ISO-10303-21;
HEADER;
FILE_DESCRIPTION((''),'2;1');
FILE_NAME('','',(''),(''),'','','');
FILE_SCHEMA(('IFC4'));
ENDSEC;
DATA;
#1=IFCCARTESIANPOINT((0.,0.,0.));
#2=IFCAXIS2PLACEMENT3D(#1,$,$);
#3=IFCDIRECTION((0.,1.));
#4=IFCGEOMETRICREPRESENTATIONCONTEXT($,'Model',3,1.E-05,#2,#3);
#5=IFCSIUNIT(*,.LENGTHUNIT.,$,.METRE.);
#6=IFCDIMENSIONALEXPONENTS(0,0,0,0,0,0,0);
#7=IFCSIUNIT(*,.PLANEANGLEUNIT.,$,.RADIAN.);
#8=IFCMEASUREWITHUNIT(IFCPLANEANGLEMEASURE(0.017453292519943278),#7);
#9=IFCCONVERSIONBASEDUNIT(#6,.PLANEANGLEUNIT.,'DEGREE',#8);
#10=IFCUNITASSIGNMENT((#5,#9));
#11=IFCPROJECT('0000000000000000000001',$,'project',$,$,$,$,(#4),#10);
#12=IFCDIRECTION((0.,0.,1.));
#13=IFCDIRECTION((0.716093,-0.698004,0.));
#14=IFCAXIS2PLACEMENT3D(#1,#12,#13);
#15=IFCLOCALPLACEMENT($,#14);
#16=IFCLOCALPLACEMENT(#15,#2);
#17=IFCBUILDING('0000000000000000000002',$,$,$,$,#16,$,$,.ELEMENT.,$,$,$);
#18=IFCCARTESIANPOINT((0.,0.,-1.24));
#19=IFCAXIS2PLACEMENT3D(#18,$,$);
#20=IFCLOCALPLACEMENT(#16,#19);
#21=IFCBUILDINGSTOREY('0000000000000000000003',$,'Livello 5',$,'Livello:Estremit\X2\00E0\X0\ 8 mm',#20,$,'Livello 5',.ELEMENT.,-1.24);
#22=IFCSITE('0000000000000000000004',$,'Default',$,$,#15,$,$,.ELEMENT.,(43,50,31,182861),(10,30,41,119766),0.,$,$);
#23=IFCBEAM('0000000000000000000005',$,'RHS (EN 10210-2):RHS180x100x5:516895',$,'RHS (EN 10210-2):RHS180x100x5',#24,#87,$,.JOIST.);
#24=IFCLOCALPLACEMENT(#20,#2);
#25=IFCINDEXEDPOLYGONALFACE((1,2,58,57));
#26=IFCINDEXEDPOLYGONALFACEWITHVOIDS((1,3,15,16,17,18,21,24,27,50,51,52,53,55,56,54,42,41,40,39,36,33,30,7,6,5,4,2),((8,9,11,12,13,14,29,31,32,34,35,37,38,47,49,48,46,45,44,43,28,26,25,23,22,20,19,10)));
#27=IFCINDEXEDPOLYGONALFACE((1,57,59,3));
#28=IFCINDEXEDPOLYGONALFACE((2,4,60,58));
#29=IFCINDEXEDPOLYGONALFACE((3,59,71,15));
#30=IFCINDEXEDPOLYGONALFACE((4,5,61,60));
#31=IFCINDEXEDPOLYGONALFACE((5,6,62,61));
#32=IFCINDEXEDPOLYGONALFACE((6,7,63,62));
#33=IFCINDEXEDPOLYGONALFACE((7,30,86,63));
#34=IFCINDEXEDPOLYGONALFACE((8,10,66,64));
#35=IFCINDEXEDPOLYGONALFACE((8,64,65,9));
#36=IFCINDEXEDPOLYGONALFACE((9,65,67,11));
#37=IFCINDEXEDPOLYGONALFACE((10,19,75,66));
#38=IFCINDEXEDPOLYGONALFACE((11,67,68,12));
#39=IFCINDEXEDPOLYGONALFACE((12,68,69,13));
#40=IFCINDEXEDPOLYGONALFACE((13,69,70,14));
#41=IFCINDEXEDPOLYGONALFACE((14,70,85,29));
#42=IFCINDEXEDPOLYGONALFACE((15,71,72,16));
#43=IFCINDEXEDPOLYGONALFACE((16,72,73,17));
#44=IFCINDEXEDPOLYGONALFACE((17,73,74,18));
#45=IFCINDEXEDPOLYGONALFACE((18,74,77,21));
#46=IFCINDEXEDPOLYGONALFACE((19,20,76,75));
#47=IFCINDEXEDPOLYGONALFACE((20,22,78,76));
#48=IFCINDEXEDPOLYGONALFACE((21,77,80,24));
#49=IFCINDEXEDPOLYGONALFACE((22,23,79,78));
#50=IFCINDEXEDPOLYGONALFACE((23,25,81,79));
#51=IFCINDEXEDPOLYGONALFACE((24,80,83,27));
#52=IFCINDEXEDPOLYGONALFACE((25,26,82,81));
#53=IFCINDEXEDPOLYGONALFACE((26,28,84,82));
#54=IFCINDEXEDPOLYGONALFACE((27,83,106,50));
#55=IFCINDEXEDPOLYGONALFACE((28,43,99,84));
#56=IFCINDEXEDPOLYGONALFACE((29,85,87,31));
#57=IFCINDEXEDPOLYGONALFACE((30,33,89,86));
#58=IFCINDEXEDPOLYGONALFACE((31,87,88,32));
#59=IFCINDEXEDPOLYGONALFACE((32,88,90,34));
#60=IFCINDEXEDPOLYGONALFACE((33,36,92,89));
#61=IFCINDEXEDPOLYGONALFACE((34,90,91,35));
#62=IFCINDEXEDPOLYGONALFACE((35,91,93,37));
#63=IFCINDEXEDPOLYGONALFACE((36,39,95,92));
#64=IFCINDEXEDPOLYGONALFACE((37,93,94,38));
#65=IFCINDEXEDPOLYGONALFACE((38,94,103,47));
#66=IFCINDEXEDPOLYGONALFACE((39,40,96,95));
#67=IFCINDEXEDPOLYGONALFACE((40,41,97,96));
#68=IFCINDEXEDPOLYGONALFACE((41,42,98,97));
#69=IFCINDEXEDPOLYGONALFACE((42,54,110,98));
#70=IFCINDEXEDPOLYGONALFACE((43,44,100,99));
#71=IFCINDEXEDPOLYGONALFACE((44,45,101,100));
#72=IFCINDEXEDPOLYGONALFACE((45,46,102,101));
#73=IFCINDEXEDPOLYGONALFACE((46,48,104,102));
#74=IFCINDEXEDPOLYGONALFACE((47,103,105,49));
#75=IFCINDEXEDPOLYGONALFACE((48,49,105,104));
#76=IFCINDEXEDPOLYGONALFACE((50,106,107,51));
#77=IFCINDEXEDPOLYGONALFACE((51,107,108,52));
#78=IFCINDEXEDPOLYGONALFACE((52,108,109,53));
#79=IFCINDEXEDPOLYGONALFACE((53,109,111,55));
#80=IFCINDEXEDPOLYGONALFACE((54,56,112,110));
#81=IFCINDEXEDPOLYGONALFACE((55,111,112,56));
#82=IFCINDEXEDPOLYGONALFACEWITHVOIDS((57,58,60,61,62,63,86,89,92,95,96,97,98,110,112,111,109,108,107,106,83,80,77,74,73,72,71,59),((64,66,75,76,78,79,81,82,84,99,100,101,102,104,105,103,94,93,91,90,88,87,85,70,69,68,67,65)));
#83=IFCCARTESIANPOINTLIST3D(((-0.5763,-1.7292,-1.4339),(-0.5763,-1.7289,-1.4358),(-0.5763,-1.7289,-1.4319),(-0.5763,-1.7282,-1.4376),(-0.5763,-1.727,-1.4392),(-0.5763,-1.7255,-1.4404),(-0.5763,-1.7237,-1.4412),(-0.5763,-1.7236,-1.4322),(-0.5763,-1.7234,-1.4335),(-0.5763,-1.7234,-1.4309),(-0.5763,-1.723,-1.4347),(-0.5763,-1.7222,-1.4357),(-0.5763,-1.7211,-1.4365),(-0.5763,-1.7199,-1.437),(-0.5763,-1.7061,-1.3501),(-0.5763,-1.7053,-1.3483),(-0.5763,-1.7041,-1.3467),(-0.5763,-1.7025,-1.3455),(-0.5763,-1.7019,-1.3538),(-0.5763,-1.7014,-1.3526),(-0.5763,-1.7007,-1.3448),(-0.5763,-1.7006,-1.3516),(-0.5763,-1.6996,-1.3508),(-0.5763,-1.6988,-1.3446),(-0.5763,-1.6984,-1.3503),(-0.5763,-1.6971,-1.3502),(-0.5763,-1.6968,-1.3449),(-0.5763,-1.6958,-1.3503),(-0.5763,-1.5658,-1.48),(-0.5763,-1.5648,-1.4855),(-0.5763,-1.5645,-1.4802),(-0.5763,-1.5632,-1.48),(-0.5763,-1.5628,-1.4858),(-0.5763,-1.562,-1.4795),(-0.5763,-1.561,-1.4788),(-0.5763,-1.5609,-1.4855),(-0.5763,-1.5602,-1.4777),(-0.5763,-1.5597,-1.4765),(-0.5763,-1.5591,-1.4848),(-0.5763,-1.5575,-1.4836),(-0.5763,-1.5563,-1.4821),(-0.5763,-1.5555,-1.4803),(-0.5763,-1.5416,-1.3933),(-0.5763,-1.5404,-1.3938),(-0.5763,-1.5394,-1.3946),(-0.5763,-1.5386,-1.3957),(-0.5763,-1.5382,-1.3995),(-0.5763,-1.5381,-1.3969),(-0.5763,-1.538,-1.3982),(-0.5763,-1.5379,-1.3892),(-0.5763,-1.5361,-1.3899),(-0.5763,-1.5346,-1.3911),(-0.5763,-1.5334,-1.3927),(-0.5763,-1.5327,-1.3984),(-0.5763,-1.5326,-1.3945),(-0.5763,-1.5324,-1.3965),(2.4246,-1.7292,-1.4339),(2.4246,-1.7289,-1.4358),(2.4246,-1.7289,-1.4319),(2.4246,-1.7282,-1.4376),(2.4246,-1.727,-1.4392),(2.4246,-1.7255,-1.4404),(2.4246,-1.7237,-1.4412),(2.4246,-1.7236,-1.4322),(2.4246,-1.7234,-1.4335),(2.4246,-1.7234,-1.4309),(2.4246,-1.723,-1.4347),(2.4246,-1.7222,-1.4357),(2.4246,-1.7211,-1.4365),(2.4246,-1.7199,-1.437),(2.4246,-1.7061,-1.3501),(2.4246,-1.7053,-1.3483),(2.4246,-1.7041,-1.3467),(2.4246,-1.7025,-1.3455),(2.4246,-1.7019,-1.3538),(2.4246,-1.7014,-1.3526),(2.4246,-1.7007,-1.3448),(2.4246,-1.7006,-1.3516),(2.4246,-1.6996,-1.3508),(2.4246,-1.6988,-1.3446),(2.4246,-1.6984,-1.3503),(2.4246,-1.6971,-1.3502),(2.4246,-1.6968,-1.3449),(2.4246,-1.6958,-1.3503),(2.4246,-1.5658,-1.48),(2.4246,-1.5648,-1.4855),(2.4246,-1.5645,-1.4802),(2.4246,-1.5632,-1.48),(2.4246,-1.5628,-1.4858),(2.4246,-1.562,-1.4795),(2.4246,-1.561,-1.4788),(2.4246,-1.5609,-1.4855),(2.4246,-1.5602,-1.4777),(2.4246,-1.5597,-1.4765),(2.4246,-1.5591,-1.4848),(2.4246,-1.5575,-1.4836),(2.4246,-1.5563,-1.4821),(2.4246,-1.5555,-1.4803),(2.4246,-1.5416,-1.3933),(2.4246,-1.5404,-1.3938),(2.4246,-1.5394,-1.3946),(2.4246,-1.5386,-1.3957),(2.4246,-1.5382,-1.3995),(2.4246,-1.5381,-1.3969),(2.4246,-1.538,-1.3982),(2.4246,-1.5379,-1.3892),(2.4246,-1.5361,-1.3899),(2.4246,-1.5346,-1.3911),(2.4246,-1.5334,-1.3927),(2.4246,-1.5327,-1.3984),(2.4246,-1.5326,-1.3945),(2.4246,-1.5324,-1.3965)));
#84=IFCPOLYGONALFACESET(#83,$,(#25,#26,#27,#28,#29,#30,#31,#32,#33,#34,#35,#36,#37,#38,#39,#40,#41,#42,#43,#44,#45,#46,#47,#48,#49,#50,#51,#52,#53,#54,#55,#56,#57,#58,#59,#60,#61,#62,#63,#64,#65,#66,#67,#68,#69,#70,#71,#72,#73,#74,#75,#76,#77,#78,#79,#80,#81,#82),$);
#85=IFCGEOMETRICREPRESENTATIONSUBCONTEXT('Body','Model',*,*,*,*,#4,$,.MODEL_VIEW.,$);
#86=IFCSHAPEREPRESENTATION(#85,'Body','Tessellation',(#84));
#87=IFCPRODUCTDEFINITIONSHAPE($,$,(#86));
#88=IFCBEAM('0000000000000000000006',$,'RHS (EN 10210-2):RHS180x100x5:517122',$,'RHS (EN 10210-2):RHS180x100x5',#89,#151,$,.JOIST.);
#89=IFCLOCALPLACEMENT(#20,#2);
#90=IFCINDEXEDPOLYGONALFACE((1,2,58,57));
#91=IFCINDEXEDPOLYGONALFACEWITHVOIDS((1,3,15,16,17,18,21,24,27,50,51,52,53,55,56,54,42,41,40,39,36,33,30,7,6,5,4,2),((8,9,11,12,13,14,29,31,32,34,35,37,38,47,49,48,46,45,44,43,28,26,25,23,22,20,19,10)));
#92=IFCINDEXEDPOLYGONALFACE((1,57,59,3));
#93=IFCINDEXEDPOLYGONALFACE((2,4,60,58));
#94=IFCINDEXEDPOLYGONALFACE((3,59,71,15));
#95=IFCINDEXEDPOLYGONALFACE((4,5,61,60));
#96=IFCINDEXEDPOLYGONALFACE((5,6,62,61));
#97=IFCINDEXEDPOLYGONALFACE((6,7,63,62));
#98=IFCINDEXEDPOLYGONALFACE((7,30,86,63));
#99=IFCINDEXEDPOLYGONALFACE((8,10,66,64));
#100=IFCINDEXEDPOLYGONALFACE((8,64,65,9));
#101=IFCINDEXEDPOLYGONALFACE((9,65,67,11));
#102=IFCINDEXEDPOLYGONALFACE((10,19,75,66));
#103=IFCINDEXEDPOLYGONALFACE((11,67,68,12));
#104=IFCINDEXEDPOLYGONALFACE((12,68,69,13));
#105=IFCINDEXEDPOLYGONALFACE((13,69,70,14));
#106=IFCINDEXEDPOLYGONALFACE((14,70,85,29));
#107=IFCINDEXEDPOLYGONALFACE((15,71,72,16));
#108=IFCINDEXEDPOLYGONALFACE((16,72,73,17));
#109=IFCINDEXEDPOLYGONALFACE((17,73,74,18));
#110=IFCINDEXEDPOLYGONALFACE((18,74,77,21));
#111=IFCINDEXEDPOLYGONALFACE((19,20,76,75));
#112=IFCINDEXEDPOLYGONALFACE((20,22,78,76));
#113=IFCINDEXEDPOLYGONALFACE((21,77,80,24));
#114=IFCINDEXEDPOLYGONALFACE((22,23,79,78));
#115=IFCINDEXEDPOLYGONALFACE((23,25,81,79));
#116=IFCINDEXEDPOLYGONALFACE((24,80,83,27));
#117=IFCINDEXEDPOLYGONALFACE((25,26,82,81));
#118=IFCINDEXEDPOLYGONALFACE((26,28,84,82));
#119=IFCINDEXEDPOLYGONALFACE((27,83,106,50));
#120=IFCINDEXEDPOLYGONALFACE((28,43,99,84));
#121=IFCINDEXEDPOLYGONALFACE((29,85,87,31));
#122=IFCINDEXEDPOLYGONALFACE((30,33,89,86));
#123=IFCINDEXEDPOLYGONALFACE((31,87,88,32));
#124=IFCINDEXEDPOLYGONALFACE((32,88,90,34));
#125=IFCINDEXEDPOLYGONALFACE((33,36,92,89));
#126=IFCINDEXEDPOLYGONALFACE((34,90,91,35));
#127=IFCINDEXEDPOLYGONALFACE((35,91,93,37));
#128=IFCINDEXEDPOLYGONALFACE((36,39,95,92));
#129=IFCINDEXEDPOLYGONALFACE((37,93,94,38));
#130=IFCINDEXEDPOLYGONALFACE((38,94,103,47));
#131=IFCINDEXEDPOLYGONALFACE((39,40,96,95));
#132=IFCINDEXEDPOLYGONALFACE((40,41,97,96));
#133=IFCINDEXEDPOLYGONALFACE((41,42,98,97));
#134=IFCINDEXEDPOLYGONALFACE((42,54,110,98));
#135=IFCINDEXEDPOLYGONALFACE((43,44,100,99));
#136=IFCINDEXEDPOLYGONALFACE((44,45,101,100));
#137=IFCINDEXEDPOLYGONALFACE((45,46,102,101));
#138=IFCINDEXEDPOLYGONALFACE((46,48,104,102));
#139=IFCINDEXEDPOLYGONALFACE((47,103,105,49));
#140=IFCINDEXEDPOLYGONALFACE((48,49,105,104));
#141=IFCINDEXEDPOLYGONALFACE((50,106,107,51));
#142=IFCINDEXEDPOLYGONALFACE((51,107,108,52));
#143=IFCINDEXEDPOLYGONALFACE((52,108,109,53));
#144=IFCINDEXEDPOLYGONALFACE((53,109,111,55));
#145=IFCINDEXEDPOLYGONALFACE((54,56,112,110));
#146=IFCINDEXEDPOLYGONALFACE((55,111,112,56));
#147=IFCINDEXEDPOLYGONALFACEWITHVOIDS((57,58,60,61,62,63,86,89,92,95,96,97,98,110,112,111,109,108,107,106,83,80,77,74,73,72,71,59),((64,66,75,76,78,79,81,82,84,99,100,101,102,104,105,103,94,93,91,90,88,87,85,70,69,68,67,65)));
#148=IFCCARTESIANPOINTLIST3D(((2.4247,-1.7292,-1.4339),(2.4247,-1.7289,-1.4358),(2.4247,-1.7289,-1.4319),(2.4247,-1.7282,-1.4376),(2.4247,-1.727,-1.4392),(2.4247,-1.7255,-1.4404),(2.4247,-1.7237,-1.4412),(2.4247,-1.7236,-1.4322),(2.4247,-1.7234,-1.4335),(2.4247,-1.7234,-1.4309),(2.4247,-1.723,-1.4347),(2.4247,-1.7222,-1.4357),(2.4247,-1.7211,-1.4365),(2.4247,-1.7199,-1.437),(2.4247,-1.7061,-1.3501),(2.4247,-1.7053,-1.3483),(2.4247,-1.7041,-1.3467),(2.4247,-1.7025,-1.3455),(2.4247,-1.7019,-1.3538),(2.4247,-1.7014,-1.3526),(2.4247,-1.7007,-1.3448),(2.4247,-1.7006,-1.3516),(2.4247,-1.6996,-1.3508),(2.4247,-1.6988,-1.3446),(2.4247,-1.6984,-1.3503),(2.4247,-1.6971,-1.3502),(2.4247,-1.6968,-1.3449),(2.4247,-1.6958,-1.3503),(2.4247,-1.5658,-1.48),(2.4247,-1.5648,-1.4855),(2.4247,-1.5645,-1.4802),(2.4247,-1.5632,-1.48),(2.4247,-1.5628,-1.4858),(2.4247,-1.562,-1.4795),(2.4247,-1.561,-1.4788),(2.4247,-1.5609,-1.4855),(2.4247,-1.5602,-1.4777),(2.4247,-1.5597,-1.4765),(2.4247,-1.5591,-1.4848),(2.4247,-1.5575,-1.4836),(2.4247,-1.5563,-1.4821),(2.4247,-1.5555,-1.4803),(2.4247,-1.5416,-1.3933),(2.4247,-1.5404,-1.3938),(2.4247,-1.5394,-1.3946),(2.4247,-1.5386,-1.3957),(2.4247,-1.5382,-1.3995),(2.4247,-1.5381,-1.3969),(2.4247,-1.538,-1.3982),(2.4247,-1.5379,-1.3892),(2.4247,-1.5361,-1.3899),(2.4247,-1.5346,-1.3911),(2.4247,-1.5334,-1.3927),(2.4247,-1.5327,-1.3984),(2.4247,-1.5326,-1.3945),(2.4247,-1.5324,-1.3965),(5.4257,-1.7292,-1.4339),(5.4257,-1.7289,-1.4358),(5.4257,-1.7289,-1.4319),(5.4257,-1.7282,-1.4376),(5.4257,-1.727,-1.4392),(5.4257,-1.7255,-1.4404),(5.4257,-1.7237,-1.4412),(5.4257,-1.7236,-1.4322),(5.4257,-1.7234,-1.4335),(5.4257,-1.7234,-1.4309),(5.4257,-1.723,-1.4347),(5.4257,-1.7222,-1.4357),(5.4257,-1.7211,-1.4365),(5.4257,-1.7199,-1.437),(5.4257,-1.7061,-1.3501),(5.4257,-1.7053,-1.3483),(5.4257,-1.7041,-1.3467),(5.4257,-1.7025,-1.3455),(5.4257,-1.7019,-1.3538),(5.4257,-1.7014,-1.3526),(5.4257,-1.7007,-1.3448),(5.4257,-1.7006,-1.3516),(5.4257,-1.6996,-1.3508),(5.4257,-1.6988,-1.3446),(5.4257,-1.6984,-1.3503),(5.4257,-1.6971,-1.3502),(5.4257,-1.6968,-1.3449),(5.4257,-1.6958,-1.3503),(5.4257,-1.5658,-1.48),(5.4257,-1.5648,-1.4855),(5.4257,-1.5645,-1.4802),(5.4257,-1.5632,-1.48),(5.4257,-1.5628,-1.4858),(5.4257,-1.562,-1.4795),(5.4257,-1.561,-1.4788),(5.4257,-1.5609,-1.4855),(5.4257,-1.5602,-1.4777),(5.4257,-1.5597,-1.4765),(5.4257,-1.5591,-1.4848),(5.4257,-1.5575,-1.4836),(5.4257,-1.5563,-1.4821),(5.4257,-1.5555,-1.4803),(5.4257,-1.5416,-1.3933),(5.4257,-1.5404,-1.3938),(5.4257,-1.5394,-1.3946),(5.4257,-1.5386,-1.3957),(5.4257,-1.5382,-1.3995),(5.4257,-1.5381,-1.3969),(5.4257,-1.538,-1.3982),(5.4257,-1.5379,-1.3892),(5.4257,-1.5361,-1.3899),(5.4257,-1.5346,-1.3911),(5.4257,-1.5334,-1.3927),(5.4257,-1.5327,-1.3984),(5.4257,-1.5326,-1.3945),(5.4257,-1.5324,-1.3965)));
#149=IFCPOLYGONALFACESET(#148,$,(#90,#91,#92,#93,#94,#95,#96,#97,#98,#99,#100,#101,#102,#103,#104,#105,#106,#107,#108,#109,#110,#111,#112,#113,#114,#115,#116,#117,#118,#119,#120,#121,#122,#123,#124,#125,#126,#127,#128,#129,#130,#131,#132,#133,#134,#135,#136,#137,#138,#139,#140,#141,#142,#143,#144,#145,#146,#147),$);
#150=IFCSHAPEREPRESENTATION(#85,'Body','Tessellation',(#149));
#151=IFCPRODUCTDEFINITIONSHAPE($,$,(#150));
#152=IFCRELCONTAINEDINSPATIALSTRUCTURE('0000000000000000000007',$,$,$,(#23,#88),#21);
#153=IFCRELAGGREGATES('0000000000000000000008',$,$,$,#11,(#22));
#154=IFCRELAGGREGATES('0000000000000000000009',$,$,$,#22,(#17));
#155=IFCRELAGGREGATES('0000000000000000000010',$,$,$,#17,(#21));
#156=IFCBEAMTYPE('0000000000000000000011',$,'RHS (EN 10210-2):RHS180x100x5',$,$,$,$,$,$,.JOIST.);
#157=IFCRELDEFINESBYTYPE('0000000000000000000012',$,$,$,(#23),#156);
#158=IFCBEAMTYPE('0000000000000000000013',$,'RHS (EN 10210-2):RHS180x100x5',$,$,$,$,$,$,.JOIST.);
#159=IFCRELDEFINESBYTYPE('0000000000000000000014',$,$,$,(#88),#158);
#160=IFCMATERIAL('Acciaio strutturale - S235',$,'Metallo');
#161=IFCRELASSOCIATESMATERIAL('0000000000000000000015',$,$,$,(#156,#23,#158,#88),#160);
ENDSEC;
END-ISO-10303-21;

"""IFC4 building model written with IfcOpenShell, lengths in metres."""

from ifc_helpers import new_model, entity, si_unit, converted_unit, direction, frame, origin, place, context, subcontext, project, spatial, line, arc, indexed_curve, outline, extrude, source, transform, mapped, material, type_object, type_shapes, element, save


model = new_model("IFC4")

# Units and contexts
model_context = context("Model", 3, precision=1e-05, world=origin(), true_north=direction((0.0, 1.0)))
body_context = subcontext(model_context, "Body", "Model", "MODEL_VIEW")
ifc_project = project(units=[si_unit("LENGTHUNIT", "METRE"), converted_unit("PLANEANGLEUNIT", "DEGREE", entity("IfcPlaneAngleMeasure", 0.017453292519943278), si_unit("PLANEANGLEUNIT", "RADIAN"), dimensions=[0, 0, 0, 0, 0, 0, 0])], contexts=[model_context])

# Site, building, storey
site_placement = place(None, frame((0.0, 0.0, 0.0), z_axis=(0.0, 0.0, 1.0), x_axis=(0.716093, -0.698004, 0.0)))
site = spatial("IfcSite", under=ifc_project, at=site_placement, Name="Default", CompositionType="ELEMENT", RefLatitude=(43, 50, 31, 182861), RefLongitude=(10, 30, 41, 119766), RefElevation=0.0)
building_placement = place(site_placement, origin())
building = spatial("IfcBuilding", under=site, at=building_placement, CompositionType="ELEMENT")
storey_placement = place(building_placement, frame((0.0, 0.0, -1.24)))
storey = spatial("IfcBuildingStorey", under=building, at=storey_placement, Name="Livello 5", ObjectType="Livello:Estremità 8 mm", LongName="Livello 5", CompositionType="ELEMENT", Elevation=-1.24)

# Beams
ifc_material_1 = material(Name="Acciaio strutturale - S235", Category="Metallo")
beam_type_1 = type_object("IfcBeamType", Name="RHS (EN 10210-2):RHS180x100x5", PredefinedType="JOIST", material=ifc_material_1)
shared_shape_1 = source(origin(), body_context, "Body", "SweptSolid", [
    extrude(outline(indexed_curve([(-0.05, -0.0825), (-0.0478, -0.0878), (-0.0425, -0.09), (0.0425, -0.09), (0.0478, -0.0878), (0.05, -0.0825), (0.05, 0.0825), (0.0478, 0.0878), (0.0425, 0.09), (-0.0425, 0.09), (-0.0478, 0.0878), (-0.05, 0.0825)], segments=[arc(1, 2, 3), line(3, 4), arc(4, 5, 6), line(6, 7), arc(7, 8, 9), line(9, 10), arc(10, 11, 12), line(12, 1)], self_intersect=False), holes=[indexed_curve([(0.04, -0.085), (-0.04, -0.085), (-0.0435, -0.0835), (-0.045, -0.08), (-0.045, 0.08), (-0.0435, 0.0835), (-0.04, 0.085), (0.04, 0.085), (0.0435, 0.0835), (0.045, 0.08), (0.045, -0.08), (0.0435, -0.0835)], segments=[line(1, 2), arc(2, 3, 4), line(4, 5), arc(5, 6, 7), line(7, 8), arc(8, 9, 10), line(10, 11), arc(11, 12, 1)], self_intersect=False)]), frame((-1.5005, 0.0, 0.0), z_axis=(1.0, 0.0, 0.0), x_axis=(0.0, -1.0, 0.0)), (0.0, 0.0, 1.0), 3.0009),
])
type_shapes(beam_type_1, [shared_shape_1])
beam_1_placement = place(storey_placement, frame((0.9241, -1.6308, -1.4152), z_axis=(0.0, 0.963256, -0.268584), x_axis=(-1.0, 0.0, 0.0)))
element("IfcBeam", 1, at=beam_1_placement, inside=storey, type_object=beam_type_1, material=ifc_material_1, Name="RHS (EN 10210-2):RHS180x100x5:516895", ObjectType="RHS (EN 10210-2):RHS180x100x5", PredefinedType="JOIST", context=body_context, shape_type="MappedRepresentation", body=[
    mapped(shared_shape_1, transform((0.0, 0.0, 0.0), scale=1.0)),
])
beam_type_2 = type_object("IfcBeamType", Name="RHS (EN 10210-2):RHS180x100x5", PredefinedType="JOIST", material=ifc_material_1)
shared_shape_2 = source(origin(), body_context, "Body", "SweptSolid", [
    extrude(outline(indexed_curve([(-0.05, -0.0825), (-0.0478, -0.0878), (-0.0425, -0.09), (0.0425, -0.09), (0.0478, -0.0878), (0.05, -0.0825), (0.05, 0.0825), (0.0478, 0.0878), (0.0425, 0.09), (-0.0425, 0.09), (-0.0478, 0.0878), (-0.05, 0.0825)], segments=[arc(1, 2, 3), line(3, 4), arc(4, 5, 6), line(6, 7), arc(7, 8, 9), line(9, 10), arc(10, 11, 12), line(12, 1)], self_intersect=False), holes=[indexed_curve([(0.04, -0.085), (-0.04, -0.085), (-0.0435, -0.0835), (-0.045, -0.08), (-0.045, 0.08), (-0.0435, 0.0835), (-0.04, 0.085), (0.04, 0.085), (0.0435, 0.0835), (0.045, 0.08), (0.045, -0.08), (0.0435, -0.0835)], segments=[line(1, 2), arc(2, 3, 4), line(4, 5), arc(5, 6, 7), line(7, 8), arc(8, 9, 10), line(10, 11), arc(11, 12, 1)], self_intersect=False)]), frame((-1.5006, 0.0, 0.0), z_axis=(1.0, 0.0, 0.0), x_axis=(0.0, -1.0, 0.0)), (0.0, 0.0, 1.0), 3.001),
])
type_shapes(beam_type_2, [shared_shape_2])
beam_2_placement = place(storey_placement, frame((3.9251, -1.6308, -1.4152), z_axis=(0.0, 0.963256, -0.268584), x_axis=(-1.0, 0.0, 0.0)))
element("IfcBeam", 2, at=beam_2_placement, inside=storey, type_object=beam_type_2, material=ifc_material_1, Name="RHS (EN 10210-2):RHS180x100x5:517122", ObjectType="RHS (EN 10210-2):RHS180x100x5", PredefinedType="JOIST", context=body_context, shape_type="MappedRepresentation", body=[
    mapped(shared_shape_2, transform((0.0, 0.0, 0.0), scale=1.0)),
])

save(model, "model.ifc")
